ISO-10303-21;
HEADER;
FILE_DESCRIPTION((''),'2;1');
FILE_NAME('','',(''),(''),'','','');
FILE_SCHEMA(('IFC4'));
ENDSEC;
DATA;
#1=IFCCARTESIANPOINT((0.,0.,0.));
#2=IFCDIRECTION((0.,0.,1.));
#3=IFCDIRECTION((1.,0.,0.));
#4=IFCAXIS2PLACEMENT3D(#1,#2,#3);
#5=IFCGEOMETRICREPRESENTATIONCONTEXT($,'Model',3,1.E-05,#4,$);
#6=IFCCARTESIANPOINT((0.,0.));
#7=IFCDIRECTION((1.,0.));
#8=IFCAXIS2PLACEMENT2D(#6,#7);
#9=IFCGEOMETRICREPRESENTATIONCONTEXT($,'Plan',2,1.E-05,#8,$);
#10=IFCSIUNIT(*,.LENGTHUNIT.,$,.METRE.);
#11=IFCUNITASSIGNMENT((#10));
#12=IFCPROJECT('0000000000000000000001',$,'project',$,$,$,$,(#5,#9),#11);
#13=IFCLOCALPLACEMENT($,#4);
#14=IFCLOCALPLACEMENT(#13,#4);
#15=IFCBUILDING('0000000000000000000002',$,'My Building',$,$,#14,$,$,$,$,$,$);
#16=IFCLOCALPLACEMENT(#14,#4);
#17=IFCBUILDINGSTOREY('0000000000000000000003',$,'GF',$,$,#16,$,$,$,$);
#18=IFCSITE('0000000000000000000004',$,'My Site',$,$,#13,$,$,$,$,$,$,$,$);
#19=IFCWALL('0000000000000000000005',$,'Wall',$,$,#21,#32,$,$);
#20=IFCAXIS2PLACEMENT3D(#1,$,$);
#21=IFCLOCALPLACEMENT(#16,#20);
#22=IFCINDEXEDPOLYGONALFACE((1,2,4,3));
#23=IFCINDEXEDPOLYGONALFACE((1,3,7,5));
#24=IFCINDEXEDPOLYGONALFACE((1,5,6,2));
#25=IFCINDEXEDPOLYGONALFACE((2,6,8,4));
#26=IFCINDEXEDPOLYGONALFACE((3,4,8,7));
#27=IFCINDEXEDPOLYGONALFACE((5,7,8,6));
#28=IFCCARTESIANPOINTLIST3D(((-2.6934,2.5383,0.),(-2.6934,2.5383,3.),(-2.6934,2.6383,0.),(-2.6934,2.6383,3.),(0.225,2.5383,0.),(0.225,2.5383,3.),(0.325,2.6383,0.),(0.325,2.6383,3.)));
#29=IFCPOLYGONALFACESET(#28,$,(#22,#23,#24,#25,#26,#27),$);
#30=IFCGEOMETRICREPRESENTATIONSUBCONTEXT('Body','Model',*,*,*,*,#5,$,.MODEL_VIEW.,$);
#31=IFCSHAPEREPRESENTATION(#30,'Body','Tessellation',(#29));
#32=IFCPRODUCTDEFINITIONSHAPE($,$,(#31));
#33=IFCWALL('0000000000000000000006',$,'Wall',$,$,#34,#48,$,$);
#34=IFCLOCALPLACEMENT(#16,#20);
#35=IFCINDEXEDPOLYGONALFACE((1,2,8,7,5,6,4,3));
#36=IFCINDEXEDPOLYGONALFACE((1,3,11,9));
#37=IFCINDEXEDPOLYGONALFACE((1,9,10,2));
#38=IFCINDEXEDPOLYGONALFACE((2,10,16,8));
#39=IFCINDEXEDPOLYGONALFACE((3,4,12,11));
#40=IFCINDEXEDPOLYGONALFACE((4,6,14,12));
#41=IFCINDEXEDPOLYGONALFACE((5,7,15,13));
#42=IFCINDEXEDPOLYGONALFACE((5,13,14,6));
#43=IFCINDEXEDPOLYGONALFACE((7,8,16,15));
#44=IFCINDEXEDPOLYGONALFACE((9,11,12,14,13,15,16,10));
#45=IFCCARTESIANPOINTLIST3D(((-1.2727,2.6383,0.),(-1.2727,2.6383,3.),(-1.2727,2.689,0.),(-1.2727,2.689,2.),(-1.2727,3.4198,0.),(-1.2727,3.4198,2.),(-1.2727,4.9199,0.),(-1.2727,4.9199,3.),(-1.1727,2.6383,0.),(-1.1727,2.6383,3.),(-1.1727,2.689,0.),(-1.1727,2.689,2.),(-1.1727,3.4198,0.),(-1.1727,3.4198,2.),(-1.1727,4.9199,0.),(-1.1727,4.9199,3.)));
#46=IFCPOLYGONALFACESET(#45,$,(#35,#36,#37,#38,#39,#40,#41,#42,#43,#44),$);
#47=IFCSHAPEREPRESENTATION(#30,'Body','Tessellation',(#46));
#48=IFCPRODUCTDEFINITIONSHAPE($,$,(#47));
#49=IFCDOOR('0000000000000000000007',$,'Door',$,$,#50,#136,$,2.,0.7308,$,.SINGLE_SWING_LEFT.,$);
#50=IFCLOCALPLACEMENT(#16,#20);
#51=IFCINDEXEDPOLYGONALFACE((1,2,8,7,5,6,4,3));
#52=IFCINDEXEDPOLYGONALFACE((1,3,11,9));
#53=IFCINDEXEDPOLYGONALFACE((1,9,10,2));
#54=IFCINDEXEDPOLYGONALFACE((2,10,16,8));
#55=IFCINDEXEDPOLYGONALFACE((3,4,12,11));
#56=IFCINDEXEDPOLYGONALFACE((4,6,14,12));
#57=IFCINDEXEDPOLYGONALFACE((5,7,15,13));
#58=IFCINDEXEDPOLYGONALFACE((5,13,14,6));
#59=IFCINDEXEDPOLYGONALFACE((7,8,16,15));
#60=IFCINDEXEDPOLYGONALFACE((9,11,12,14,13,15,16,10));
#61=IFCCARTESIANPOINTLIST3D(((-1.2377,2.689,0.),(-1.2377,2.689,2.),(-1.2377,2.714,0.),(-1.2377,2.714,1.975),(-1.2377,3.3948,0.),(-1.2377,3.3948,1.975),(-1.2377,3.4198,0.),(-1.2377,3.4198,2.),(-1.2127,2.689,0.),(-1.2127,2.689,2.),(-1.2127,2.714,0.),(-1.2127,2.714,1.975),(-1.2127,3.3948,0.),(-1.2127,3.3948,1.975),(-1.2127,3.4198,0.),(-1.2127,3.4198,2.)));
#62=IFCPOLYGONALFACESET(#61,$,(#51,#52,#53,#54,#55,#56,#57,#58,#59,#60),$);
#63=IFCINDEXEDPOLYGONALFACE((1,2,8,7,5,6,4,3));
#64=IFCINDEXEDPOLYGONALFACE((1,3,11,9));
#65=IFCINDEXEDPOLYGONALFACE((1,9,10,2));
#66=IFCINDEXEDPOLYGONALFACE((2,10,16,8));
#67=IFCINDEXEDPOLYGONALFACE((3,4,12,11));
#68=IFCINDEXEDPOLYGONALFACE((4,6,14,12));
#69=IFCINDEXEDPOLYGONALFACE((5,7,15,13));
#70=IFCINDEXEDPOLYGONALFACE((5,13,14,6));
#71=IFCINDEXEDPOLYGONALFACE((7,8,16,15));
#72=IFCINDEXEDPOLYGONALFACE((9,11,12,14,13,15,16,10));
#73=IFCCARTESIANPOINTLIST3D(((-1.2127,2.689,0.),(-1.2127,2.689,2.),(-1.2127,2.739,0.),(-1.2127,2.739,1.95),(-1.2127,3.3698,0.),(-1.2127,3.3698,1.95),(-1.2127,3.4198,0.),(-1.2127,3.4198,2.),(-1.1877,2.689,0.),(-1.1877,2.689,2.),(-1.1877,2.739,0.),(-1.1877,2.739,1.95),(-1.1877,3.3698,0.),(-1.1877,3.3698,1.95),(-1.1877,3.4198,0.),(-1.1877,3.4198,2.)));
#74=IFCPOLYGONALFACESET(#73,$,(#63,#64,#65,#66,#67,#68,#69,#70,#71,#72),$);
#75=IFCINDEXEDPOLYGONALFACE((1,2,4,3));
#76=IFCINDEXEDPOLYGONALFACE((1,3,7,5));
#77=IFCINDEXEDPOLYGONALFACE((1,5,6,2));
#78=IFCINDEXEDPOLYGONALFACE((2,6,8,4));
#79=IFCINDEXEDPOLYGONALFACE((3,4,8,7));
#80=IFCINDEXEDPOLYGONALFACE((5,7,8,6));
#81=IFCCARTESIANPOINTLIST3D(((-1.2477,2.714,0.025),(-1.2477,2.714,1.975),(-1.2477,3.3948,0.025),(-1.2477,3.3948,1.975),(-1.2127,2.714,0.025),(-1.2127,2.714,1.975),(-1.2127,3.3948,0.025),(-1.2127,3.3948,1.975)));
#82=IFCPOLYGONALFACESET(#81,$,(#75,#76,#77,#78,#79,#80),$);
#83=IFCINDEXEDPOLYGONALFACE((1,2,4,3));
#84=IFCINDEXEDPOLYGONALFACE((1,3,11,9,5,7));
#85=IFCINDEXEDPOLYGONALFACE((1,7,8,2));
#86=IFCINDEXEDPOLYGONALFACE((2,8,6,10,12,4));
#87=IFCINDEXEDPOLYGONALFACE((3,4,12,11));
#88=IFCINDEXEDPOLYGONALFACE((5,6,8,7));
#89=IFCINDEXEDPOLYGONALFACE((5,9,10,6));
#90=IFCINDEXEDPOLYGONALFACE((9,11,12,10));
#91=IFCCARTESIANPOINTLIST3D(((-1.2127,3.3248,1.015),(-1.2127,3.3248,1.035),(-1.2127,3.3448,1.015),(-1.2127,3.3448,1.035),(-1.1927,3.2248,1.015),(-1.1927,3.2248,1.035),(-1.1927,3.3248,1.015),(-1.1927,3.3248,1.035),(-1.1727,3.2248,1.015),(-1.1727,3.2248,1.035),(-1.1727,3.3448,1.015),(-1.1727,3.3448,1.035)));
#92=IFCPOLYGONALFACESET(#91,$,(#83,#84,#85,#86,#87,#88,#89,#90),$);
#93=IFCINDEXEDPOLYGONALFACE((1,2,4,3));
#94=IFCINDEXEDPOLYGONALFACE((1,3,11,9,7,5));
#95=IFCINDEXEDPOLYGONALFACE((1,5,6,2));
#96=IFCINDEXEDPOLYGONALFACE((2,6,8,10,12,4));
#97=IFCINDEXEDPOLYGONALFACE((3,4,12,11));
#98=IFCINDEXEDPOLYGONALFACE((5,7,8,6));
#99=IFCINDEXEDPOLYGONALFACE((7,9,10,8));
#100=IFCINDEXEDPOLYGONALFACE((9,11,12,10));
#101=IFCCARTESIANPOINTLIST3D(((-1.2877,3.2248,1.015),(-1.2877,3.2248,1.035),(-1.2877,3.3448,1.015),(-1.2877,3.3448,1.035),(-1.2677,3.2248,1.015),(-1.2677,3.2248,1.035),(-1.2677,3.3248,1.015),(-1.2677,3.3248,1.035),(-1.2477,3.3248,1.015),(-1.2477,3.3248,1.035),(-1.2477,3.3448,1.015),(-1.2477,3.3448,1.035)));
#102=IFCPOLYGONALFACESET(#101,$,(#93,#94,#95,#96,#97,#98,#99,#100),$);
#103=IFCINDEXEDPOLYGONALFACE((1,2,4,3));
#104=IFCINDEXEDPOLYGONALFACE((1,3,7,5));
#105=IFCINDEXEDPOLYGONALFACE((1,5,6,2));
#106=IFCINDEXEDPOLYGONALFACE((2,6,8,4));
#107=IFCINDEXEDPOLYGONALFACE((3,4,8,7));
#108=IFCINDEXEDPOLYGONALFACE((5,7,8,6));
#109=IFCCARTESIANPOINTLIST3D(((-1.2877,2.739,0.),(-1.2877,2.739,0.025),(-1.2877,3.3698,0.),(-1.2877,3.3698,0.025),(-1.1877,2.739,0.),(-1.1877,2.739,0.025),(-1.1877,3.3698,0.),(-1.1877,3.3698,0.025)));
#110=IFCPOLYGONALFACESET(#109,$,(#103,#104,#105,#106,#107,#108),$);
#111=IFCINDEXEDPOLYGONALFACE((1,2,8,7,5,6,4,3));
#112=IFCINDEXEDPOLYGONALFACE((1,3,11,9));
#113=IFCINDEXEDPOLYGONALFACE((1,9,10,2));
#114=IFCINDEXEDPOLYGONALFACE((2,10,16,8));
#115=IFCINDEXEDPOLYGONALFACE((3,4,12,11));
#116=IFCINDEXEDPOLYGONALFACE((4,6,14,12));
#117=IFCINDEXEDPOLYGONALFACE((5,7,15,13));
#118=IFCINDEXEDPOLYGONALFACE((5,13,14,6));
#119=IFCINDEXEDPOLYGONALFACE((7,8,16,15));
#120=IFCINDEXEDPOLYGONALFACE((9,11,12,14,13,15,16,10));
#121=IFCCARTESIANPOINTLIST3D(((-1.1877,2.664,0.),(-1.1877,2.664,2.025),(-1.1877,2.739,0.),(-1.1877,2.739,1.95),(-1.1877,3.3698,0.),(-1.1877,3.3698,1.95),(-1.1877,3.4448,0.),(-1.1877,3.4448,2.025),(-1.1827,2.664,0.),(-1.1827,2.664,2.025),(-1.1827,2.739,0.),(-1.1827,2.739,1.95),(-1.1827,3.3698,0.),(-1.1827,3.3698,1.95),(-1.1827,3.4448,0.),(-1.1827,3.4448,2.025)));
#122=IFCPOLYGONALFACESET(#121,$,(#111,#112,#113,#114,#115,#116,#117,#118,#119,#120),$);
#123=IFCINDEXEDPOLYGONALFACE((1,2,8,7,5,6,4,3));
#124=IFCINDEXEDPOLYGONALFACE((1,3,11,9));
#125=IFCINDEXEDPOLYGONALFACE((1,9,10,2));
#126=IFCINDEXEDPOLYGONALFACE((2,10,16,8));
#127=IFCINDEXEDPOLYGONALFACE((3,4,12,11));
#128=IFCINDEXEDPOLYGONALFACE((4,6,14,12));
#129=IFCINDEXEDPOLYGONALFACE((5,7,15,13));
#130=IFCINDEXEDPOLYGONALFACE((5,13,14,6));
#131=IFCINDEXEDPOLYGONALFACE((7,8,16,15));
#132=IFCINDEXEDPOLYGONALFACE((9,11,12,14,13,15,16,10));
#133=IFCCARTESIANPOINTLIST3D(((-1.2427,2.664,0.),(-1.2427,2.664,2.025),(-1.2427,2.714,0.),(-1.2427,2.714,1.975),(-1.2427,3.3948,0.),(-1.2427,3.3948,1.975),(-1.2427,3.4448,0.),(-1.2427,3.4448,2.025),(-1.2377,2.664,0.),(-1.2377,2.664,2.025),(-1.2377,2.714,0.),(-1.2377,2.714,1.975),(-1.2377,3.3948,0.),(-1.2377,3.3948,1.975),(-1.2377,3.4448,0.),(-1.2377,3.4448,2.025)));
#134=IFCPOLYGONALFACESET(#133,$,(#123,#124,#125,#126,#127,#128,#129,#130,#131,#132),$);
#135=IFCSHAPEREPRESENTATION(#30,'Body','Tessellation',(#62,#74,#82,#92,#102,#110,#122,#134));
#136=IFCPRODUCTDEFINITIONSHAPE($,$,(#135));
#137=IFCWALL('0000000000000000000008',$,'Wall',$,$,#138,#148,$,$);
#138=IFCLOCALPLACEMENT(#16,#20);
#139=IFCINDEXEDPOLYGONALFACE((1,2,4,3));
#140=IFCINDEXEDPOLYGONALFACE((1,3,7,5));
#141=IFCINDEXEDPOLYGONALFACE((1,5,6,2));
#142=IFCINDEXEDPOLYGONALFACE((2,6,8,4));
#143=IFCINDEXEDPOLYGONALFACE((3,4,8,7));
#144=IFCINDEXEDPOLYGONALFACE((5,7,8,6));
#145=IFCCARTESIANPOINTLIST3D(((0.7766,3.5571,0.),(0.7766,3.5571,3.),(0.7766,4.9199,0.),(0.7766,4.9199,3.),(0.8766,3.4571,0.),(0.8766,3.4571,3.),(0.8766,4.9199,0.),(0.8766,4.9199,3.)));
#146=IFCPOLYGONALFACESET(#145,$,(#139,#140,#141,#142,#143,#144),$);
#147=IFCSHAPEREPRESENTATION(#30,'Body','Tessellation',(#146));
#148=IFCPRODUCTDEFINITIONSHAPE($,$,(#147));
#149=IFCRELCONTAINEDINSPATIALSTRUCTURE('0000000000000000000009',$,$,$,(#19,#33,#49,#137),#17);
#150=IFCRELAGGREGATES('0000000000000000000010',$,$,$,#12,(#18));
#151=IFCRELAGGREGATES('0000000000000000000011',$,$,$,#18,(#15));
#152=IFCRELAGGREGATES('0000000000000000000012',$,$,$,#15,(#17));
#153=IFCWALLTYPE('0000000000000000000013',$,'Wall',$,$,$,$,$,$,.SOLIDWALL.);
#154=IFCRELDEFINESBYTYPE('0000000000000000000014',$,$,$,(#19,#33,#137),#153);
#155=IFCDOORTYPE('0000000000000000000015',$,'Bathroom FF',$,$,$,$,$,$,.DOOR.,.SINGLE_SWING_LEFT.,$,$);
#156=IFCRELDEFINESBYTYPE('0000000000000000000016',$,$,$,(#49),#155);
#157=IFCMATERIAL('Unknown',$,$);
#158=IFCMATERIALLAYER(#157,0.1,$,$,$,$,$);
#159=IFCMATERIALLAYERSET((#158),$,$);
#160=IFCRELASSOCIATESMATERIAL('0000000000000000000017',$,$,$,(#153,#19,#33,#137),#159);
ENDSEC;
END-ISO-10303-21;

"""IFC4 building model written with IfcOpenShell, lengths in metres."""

from ifc_helpers import new_model, entity, si_unit, frame, origin_with_axes, origin_2d_with_axis, place, context, subcontext, project, spatial, line, indexed_curve, outline, extrude, shape, source, transform, mapped, material, layer, layer_set, layer_usage, type_object, type_shapes, element, fill, save


model = new_model("IFC4")

# Units and contexts
model_context = context("Model", 3, precision=1e-05, world=origin_with_axes())
plan_context = context("Plan", 2, precision=1e-05, world=origin_2d_with_axis())
body_context_1 = subcontext(model_context, "Body", "Model", "MODEL_VIEW")
body_context_2 = subcontext(plan_context, "Body", "Plan", "PLAN_VIEW")
ifc_project = project(units=[si_unit("LENGTHUNIT", "METRE")], contexts=[model_context, plan_context])

# Site, building, storey
site_placement = place(None, origin_with_axes())
site = spatial("IfcSite", under=ifc_project, at=site_placement, Name="My Site")
building_placement = place(site_placement, origin_with_axes())
building = spatial("IfcBuilding", under=site, at=building_placement, Name="My Building")
storey_placement = place(building_placement, origin_with_axes())
storey = spatial("IfcBuildingStorey", under=building, at=storey_placement, Name="GF")

# Shared definitions
ifc_material_1 = material(Name="Unknown")

# Shared definitions
ifc_layer_1 = layer(ifc_material_1, 0.1)
ifc_layer_set_1 = layer_set([ifc_layer_1])
wall_type = type_object("IfcWallType", Name="Wall", PredefinedType="SOLIDWALL", material=ifc_layer_set_1)

# Wall
ifc_layer_usage_1 = layer_usage(ifc_layer_set_1, "AXIS2", "POSITIVE", 0.0)
wall_1_placement = place(storey_placement, frame((0.325, 2.6383, 0.0), z_axis=(0.0, 0.0, 1.0), x_axis=(-1.0, 0.0, 0.0)))
element("IfcWall", 1, at=wall_1_placement, inside=storey, type_object=wall_type, material=ifc_layer_usage_1, Name="Wall", context=body_context_1, shape_type="SweptSolid", body=[
    extrude(outline(indexed_curve([(0.0, 0.0), (0.1, 0.1), (3.0184, 0.1), (3.0184, 0.0)], segments=[line(1, 2, 3, 4, 1)])), origin_with_axes(), (0.0, 0.0, 1.0), 3.0),
])

# Wall, opening, door
ifc_layer_usage_2 = layer_usage(ifc_layer_set_1, "AXIS2", "POSITIVE", 0.0)
wall_2_placement = place(storey_placement, frame((-1.1727, 2.6383, 0.0), z_axis=(0.0, 0.0, 1.0), x_axis=(0.0, 1.0, 0.0)))
wall_2 = element("IfcWall", 2, at=wall_2_placement, inside=storey, type_object=wall_type, material=ifc_layer_usage_2, Name="Wall", context=body_context_1, shape_type="SweptSolid", body=[
    extrude(outline(indexed_curve([(0.0, 0.0), (0.0, 0.1), (2.2816, 0.1), (2.2816, 0.0)], segments=[line(1, 2, 3, 4, 1)])), origin_with_axes(), (0.0, 0.0, 1.0), 3.0),
])
shared_shape_1 = source(origin_with_axes(), body_context_1, "Body", "SweptSolid", [
    extrude(outline(indexed_curve([(0.0, 0.0), (0.7308, 0.0), (0.7308, 2.0), (0.0, 2.0)], segments=[line(1, 2, 3, 4, 1)])), frame((0.0, -0.6, 0.0), z_axis=(0.0, -1.0, 0.0), x_axis=(1.0, 0.0, 0.0)), (0.0, 0.0, -1.0), 1.2),
])
opening_1_placement = place(wall_2_placement, frame((0.0507, 0.015, 0.0), z_axis=(0.0, 0.0, 1.0), x_axis=(1.0, 0.0, 0.0)))
opening_1 = element("IfcOpeningElement", 3, at=opening_1_placement, cuts=wall_2, PredefinedType="OPENING", context=body_context_1, shape_type="MappedRepresentation", body=[
    mapped(shared_shape_1, transform((0.0, 0.0, 0.0), x_axis=(1.0, 0.0, 0.0), y_axis=(0.0, 1.0, 0.0), z_axis=(0.0, 0.0, 1.0), scale=1.0)),
])
door_type_1 = type_object("IfcDoorType", Name="Bathroom FF", OperationType="SINGLE_SWING_LEFT", PredefinedType="DOOR")
shared_shape_2 = source(origin_with_axes(), body_context_1, "Body", "SweptSolid", [
    extrude(outline(indexed_curve([(0.0, 0.0), (0.0, 2.0), (0.7308, 2.0), (0.7308, 0.0), (0.7058, 0.0), (0.7058, 1.975), (0.025, 1.975), (0.025, 0.0)], segments=[line(1, 2, 3, 4, 5, 6, 7, 8, 1)])), frame((0.0, 0.025, 0.0), z_axis=(0.0, -1.0, 0.0), x_axis=(1.0, 0.0, 0.0)), (0.0, 0.0, -1.0), 0.025),
    extrude(outline(indexed_curve([(0.0, 0.0), (0.0, 2.0), (0.7308, 2.0), (0.7308, 0.0), (0.6808, 0.0), (0.6808, 1.95), (0.05, 1.95), (0.05, 0.0)], segments=[line(1, 2, 3, 4, 5, 6, 7, 8, 1)])), frame((0.0, 0.0, 0.0), z_axis=(0.0, -1.0, 0.0), x_axis=(1.0, 0.0, 0.0)), (0.0, 0.0, -1.0), 0.025),
    extrude(outline(indexed_curve([(0.0, 0.0), (0.6808, 0.0), (0.6808, 0.035), (0.0, 0.035)], segments=[line(1, 2, 3, 4, 1)])), frame((0.025, 0.025, 0.025), z_axis=(0.0, 0.0, 1.0), x_axis=(1.0, 0.0, 0.0)), (0.0, 0.0, 1.0), 1.95),
    extrude(outline(indexed_curve([(0.0, 0.0), (0.0, -0.04), (-0.12, -0.04), (-0.12, -0.02), (-0.02, -0.02), (-0.02, 0.0)], segments=[line(1, 2, 3, 4, 5, 6, 1)])), frame((0.6558, 0.025, 1.015), z_axis=(0.0, 0.0, 1.0), x_axis=(1.0, 0.0, 0.0)), (0.0, 0.0, 1.0), 0.02),
    extrude(outline(indexed_curve([(0.0, 0.0), (0.0, 0.04), (-0.12, 0.04), (-0.12, 0.02), (-0.02, 0.02), (-0.02, 0.0)], segments=[line(1, 2, 3, 4, 5, 6, 1)])), frame((0.6558, 0.06, 1.015), z_axis=(0.0, 0.0, 1.0), x_axis=(1.0, 0.0, 0.0)), (0.0, 0.0, 1.0), 0.02),
    extrude(outline(indexed_curve([(0.0, 0.0), (0.6308, 0.0), (0.6308, 0.1), (0.0, 0.1)], segments=[line(1, 2, 3, 4, 1)])), frame((0.05, 0.0, 0.0), z_axis=(0.0, 0.0, 1.0), x_axis=(1.0, 0.0, 0.0)), (0.0, 0.0, 1.0), 0.025),
    extrude(outline(indexed_curve([(0.0, 0.0), (0.0, 2.025), (0.7808, 2.025), (0.7808, 0.0), (0.7058, 0.0), (0.7058, 1.95), (0.075, 1.95), (0.075, 0.0)], segments=[line(1, 2, 3, 4, 5, 6, 7, 8, 1)])), frame((-0.025, -0.005, 0.0), z_axis=(0.0, -1.0, 0.0), x_axis=(1.0, 0.0, 0.0)), (0.0, 0.0, -1.0), 0.005),
    extrude(outline(indexed_curve([(0.0, 0.0), (0.0, 2.025), (0.7808, 2.025), (0.7808, 0.0), (0.7308, 0.0), (0.7308, 1.975), (0.05, 1.975), (0.05, 0.0)], segments=[line(1, 2, 3, 4, 5, 6, 7, 8, 1)])), frame((-0.025, 0.05, 0.0), z_axis=(0.0, -1.0, 0.0), x_axis=(1.0, 0.0, 0.0)), (0.0, 0.0, -1.0), 0.005),
])
shared_shape_3 = source(origin_with_axes(), body_context_2, "Body", "Curve2D", [
    entity("IfcIndexedPolyCurve", entity("IfcCartesianPointList2D", [[0.0, 0.0], [0.0, 0.05], [0.025, 0.05], [0.025, 0.025], [0.05, 0.025], [0.05, 0.0]]), [entity("IfcLineIndex", [1, 2, 3, 4, 5, 6, 1])]),
    entity("IfcIndexedPolyCurve", entity("IfcCartesianPointList2D", [[0.7308, 0.0], [0.7308, 0.05], [0.7058, 0.05], [0.7058, 0.025], [0.6808, 0.025], [0.6808, 0.0]]), [entity("IfcLineIndex", [1, 2, 3, 4, 5, 6, 1])]),
    entity("IfcTrimmedCurve", entity("IfcEllipse", entity("IfcAxis2Placement2D", entity("IfcCartesianPoint", [0.06, 0.05]), entity("IfcDirection", [1.0, 0.0])), 0.6458, 0.6808), [entity("IfcCartesianPoint", [0.7058, 0.05])], [entity("IfcCartesianPoint", [0.06, 0.7308])], True, "CARTESIAN"),
    entity("IfcIndexedPolyCurve", entity("IfcCartesianPointList2D", [[0.025, 0.05], [0.06, 0.05], [0.06, 0.7308], [0.025, 0.7308]]), [entity("IfcLineIndex", [1, 2, 3, 4, 1])]),
])
type_shapes(door_type_1, [shared_shape_2, shared_shape_3])
door_1_placement = place(opening_1_placement, frame((0.0, 0.0, 0.0), z_axis=(0.0, 0.0, 1.0), x_axis=(1.0, 0.0, 0.0)))
door_1 = element("IfcDoor", 4, at=door_1_placement, inside=storey, type_object=door_type_1, Name="Door", OperationType="SINGLE_SWING_LEFT", OverallHeight=2.0, OverallWidth=0.7308, shapes=[
    shape(body_context_1, "Body", "MappedRepresentation", [mapped(shared_shape_2, transform((0.0, 0.0, 0.0), x_axis=(1.0, 0.0, 0.0), y_axis=(0.0, 1.0, 0.0), z_axis=(0.0, 0.0, 1.0), scale=1.0))]),
    shape(body_context_2, "Body", "MappedRepresentation", [mapped(shared_shape_3, transform((0.0, 0.0, 0.0), x_axis=(1.0, 0.0, 0.0), y_axis=(0.0, 1.0, 0.0), z_axis=(0.0, 0.0, 1.0), scale=1.0))]),
])
fill(opening_1, door_1)

# Wall
ifc_layer_usage_3 = layer_usage(ifc_layer_set_1, "AXIS2", "POSITIVE", 0.0)
wall_3_placement = place(storey_placement, frame((0.7766, 5.0199, 0.0), z_axis=(0.0, 0.0, 1.0), x_axis=(0.0, -1.0, 0.0)))
element("IfcWall", 5, at=wall_3_placement, inside=storey, type_object=wall_type, material=ifc_layer_usage_3, Name="Wall", context=body_context_1, shape_type="SweptSolid", body=[
    extrude(outline(indexed_curve([(0.1, 0.0), (0.1, 0.1), (1.5628, 0.1), (1.4628, 0.0)], segments=[line(1, 2, 3, 4, 1)])), origin_with_axes(), (0.0, 0.0, 1.0), 3.0),
])

save(model, "model.ifc")
